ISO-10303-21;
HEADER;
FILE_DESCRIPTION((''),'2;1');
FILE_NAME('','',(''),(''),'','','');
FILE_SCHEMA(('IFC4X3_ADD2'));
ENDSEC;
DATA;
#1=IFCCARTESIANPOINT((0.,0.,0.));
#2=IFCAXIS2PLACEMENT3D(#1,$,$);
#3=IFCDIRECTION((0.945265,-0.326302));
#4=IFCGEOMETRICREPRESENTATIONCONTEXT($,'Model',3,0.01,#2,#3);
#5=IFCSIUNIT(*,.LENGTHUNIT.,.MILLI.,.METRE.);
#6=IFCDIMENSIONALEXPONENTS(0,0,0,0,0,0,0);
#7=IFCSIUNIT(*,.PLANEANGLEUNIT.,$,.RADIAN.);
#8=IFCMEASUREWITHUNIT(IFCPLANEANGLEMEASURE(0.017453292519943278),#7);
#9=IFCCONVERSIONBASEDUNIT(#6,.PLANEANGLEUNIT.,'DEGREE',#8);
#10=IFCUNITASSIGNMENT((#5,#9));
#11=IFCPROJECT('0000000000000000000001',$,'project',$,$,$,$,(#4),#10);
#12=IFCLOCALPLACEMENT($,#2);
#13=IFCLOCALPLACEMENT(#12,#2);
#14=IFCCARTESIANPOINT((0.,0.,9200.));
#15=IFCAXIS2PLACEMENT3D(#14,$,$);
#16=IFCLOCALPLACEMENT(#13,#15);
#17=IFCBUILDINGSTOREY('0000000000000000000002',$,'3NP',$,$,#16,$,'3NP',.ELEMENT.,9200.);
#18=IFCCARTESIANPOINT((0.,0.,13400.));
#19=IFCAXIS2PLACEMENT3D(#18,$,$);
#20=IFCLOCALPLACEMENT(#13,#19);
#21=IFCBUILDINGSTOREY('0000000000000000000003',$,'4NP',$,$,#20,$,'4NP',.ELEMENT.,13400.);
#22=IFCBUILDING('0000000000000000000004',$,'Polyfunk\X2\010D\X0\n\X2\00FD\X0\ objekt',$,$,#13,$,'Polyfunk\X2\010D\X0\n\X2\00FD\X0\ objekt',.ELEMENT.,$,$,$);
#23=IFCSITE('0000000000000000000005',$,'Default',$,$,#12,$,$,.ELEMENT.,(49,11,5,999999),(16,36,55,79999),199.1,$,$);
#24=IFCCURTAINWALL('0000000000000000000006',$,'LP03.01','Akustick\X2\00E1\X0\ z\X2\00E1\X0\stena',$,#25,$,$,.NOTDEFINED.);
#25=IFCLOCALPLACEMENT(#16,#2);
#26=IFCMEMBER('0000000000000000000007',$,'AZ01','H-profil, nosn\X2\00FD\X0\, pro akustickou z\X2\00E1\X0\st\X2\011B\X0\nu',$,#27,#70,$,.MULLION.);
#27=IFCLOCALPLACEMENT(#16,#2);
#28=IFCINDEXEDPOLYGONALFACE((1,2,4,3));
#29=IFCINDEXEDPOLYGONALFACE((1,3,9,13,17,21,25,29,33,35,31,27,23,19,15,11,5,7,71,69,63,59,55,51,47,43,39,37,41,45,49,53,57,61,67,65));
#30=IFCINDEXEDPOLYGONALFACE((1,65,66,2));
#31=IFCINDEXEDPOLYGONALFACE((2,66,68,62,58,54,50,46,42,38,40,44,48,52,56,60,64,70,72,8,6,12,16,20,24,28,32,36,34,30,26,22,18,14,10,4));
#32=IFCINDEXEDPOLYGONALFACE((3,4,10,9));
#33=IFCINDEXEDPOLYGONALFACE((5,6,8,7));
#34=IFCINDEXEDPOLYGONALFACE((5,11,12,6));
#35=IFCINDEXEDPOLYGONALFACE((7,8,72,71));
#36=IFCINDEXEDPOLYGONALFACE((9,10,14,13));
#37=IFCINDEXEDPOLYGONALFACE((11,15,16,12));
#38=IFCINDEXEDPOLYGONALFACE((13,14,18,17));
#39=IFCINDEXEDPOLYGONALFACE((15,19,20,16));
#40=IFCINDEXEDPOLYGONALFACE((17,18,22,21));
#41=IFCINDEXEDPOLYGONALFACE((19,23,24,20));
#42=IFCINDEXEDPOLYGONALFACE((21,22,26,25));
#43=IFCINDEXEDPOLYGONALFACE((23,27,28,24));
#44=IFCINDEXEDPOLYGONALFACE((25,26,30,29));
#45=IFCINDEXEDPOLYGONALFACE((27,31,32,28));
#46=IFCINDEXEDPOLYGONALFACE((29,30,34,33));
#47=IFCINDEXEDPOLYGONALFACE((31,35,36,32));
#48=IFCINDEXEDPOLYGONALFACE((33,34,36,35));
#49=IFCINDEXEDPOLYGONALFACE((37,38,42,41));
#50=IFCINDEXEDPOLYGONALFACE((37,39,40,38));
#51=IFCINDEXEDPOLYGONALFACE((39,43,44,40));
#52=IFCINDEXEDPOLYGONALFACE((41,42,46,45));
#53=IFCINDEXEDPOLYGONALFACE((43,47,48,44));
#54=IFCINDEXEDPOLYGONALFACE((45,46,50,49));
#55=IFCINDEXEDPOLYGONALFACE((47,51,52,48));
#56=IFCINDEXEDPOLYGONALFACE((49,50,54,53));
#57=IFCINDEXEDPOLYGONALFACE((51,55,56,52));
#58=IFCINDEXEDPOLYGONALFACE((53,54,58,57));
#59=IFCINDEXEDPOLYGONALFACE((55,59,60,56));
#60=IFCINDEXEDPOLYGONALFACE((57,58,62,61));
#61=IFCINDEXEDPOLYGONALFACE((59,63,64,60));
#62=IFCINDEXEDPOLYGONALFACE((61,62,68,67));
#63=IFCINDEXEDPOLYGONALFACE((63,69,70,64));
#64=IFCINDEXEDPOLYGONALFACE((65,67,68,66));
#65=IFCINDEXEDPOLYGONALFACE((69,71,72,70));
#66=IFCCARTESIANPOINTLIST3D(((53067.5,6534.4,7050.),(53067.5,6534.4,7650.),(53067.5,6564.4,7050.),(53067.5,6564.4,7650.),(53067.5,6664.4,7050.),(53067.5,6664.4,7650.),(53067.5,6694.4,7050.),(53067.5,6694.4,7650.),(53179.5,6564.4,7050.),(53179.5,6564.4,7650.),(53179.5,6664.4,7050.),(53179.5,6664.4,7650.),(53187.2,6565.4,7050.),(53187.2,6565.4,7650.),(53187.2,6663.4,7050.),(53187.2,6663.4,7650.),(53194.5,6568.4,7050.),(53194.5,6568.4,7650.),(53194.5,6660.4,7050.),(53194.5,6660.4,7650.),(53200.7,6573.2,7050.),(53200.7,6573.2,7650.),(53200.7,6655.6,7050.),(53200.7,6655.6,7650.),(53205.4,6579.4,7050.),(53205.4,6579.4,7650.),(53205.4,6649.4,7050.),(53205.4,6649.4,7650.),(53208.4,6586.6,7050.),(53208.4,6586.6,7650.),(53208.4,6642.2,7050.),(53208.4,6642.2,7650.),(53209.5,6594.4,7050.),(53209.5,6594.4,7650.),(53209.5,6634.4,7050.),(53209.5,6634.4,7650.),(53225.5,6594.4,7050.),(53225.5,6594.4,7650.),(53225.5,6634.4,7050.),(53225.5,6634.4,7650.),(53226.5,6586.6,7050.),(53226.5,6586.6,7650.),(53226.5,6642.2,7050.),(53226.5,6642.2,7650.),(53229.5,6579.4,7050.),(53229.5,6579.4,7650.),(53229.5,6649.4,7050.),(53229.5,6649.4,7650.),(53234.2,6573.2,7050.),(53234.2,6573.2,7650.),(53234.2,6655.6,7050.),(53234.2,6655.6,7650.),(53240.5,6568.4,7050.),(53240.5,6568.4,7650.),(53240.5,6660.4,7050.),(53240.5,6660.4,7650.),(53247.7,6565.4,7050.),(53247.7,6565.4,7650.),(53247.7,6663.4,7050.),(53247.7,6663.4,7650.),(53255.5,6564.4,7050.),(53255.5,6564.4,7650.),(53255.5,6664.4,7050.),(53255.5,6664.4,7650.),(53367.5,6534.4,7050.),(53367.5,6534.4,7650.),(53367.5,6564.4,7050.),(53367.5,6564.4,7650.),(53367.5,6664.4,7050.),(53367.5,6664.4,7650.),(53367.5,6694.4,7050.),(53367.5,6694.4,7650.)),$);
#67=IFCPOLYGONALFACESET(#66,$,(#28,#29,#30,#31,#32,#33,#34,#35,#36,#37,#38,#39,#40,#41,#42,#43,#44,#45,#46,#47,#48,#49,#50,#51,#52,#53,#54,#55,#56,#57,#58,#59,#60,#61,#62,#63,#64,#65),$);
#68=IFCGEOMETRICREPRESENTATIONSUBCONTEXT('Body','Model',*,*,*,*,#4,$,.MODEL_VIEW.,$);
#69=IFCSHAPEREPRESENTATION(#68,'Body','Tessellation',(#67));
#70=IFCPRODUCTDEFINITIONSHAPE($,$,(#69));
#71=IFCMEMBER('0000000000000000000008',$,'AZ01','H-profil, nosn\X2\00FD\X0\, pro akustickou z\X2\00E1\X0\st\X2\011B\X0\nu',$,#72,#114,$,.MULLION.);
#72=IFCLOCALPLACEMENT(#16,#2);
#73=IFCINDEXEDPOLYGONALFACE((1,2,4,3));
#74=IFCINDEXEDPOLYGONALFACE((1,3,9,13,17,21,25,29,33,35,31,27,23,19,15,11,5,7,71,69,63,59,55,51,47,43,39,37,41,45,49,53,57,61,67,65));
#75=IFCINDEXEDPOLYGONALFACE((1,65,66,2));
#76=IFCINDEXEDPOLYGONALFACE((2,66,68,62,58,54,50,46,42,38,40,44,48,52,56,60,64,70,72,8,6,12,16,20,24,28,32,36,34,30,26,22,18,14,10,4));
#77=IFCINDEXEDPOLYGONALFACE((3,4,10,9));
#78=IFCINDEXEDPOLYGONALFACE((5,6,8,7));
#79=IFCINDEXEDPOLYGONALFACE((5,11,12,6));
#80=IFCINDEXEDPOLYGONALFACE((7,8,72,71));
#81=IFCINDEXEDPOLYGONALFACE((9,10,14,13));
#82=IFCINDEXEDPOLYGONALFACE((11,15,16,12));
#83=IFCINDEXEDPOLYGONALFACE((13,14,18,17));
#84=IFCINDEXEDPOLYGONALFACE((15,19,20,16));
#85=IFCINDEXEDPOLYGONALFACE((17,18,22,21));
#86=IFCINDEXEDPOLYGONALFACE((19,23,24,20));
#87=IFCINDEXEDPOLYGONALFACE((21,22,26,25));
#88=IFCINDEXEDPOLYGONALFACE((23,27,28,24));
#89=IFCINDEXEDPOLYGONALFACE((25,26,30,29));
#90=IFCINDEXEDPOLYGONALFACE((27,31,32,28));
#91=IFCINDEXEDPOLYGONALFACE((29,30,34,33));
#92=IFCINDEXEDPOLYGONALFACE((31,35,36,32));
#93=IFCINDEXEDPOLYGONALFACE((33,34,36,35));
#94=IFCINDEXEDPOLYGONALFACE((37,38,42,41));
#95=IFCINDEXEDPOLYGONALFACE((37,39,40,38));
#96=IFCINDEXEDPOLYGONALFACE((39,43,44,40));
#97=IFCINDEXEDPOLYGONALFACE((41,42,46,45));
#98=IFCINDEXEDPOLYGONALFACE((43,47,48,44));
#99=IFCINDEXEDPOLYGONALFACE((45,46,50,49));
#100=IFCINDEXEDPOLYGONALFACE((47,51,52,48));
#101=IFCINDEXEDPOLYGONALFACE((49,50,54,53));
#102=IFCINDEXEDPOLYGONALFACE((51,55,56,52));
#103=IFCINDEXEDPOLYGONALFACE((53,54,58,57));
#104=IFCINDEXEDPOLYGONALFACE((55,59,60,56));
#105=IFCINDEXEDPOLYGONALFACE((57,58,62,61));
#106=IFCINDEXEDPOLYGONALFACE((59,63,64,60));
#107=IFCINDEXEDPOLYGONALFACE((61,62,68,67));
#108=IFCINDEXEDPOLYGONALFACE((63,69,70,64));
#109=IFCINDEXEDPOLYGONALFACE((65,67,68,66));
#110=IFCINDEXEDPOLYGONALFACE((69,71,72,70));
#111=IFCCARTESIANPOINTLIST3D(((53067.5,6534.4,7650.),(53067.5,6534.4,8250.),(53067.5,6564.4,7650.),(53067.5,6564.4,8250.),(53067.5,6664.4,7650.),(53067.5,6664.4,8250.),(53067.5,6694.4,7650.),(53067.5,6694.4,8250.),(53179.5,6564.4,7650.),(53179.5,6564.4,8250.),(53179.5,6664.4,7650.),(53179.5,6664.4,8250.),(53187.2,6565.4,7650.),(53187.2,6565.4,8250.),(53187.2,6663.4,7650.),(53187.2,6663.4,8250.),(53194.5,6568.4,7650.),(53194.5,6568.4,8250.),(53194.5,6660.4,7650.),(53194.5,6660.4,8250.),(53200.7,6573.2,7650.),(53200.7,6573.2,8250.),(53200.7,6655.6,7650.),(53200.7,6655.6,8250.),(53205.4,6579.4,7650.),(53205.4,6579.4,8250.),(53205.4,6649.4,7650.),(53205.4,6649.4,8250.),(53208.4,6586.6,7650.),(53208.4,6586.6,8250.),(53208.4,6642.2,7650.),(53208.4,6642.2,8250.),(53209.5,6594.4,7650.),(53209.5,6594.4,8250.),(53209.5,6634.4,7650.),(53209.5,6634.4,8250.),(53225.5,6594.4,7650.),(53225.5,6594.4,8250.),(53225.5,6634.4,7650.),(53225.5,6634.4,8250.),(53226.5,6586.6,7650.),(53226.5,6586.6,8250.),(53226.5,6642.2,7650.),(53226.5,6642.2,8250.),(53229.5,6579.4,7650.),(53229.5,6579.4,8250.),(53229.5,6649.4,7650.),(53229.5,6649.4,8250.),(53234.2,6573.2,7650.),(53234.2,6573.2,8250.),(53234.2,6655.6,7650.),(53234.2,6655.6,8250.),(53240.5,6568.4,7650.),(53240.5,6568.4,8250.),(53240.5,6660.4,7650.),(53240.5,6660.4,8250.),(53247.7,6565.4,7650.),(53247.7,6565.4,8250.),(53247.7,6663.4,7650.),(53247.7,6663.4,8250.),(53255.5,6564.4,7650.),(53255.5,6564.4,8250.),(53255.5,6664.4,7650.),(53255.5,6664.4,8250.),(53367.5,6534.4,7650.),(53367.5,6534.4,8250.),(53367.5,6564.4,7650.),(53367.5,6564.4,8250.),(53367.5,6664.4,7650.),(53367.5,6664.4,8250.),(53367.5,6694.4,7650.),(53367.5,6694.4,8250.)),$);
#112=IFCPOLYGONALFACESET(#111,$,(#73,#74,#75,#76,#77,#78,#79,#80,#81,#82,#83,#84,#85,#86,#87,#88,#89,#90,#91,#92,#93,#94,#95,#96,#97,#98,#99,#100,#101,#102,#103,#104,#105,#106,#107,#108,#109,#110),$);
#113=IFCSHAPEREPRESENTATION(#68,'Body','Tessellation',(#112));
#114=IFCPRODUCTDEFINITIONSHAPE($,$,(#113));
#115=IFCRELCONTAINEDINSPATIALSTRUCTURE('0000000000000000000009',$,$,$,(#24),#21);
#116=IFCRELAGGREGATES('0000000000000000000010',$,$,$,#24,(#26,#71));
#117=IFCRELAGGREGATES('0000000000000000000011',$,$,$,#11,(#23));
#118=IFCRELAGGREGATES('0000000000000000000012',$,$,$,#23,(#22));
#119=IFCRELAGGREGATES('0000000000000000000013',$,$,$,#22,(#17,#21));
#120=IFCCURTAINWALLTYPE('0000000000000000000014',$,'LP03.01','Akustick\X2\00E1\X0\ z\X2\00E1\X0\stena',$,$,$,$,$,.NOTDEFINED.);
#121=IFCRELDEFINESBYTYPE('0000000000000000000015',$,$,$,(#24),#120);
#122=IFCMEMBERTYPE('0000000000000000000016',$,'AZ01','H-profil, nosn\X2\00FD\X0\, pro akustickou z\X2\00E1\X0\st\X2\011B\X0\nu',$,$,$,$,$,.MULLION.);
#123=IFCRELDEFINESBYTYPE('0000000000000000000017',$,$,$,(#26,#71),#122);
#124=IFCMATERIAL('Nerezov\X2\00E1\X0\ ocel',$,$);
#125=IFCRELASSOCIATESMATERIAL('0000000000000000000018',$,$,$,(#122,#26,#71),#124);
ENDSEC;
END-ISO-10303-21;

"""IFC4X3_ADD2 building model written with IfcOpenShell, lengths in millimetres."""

from ifc_helpers import new_model, entity, si_unit, converted_unit, direction, frame, frame_2d, origin, place, context, subcontext, project, spatial, polyline, circle_curve, parameter, trimmed, segment, composite_curve, outline, extrude, source, transform, mapped, material, material_profile, profile_set, profile_usage, type_object, element, aggregate, save


model = new_model("IFC4X3_ADD2")

# Units and contexts
model_context = context("Model", 3, precision=0.01, world=origin(), true_north=direction((0.945265, -0.326302)))
body_context = subcontext(model_context, "Body", "Model", "MODEL_VIEW")
ifc_project = project(units=[si_unit("LENGTHUNIT", "METRE", prefix="MILLI"), converted_unit("PLANEANGLEUNIT", "DEGREE", entity("IfcPlaneAngleMeasure", 0.017453292519943278), si_unit("PLANEANGLEUNIT", "RADIAN"), dimensions=[0, 0, 0, 0, 0, 0, 0])], contexts=[model_context])

# Site, building, storey
site_placement = place(None, origin())
site = spatial("IfcSite", under=ifc_project, at=site_placement, Name="Default", CompositionType="ELEMENT", RefLatitude=(49, 11, 5, 999999), RefLongitude=(16, 36, 55, 79999), RefElevation=199.1)
building_placement = place(site_placement, origin())
building = spatial("IfcBuilding", under=site, at=building_placement, Name="Polyfunkčný objekt", LongName="Polyfunkčný objekt", CompositionType="ELEMENT")
storey_1_placement = place(building_placement, frame((0.0, 0.0, 9200.0)))
storey_1 = spatial("IfcBuildingStorey", under=building, at=storey_1_placement, Name="3NP", LongName="3NP", CompositionType="ELEMENT", Elevation=9200.0)

# Shared definitions
storey_2_placement = place(building_placement, frame((0.0, 0.0, 13400.0)))
storey_2 = spatial("IfcBuildingStorey", under=building, at=storey_2_placement, Name="4NP", LongName="4NP", CompositionType="ELEMENT", Elevation=13400.0)

# Curtain wall, members
curtain_wall_type_1 = type_object("IfcCurtainWallType", Name="LP03.01", Description="Akustická zástena", PredefinedType="NOTDEFINED")
curtain_wall_1_placement = place(storey_2_placement, frame((0.0, 0.0, -13400.0)))
curtain_wall_1 = element("IfcCurtainWall", 1, at=curtain_wall_1_placement, inside=storey_2, type_object=curtain_wall_type_1, Name="LP03.01", Description="Akustická zástena", PredefinedType="NOTDEFINED")
ifc_material_1 = material(Name="Nerezová ocel")
ifc_material_profile_1 = material_profile(ifc_material_1, outline(composite_curve([segment(polyline([(50.0, -150.0), (80.0, -150.0)]), True, "CONTINUOUS"), segment(polyline([(80.0, -150.0), (80.0, 150.0)]), True, "CONTINUOUS"), segment(polyline([(80.0, 150.0), (50.0, 150.0)]), True, "CONTINUOUS"), segment(polyline([(50.0, 150.0), (50.0, 38.0)]), True, "CONTINUOUS"), segment(trimmed(circle_curve(frame_2d((20.0, 38.0), x_axis=(0.0, 1.0)), 30.0), [parameter(180.0)], [parameter(270.0)], True, "PARAMETER"), False, "CONTINUOUS"), segment(polyline([(20.0, 8.0), (-20.0, 8.0)]), True, "CONTINUOUS"), segment(trimmed(circle_curve(frame_2d((-20.0, 38.0), x_axis=(0.0, 1.0)), 30.0), [parameter(90.0)], [parameter(180.0)], True, "PARAMETER"), False, "CONTINUOUS"), segment(polyline([(-50.0, 38.0), (-50.0, 150.0)]), True, "CONTINUOUS"), segment(polyline([(-50.0, 150.0), (-80.0, 150.0)]), True, "CONTINUOUS"), segment(polyline([(-80.0, 150.0), (-80.0, -150.0)]), True, "CONTINUOUS"), segment(polyline([(-80.0, -150.0), (-50.0, -150.0)]), True, "CONTINUOUS"), segment(polyline([(-50.0, -150.0), (-50.0, -38.0)]), True, "CONTINUOUS"), segment(trimmed(circle_curve(frame_2d((-20.0, -38.0), x_axis=(0.0, 1.0)), 30.0), [parameter(0.0)], [parameter(90.0)], True, "PARAMETER"), False, "CONTINUOUS"), segment(polyline([(-20.0, -8.0), (20.0, -8.0)]), True, "CONTINUOUS"), segment(trimmed(circle_curve(frame_2d((20.0, -38.0), x_axis=(0.0, 1.0)), 30.0), [parameter(270.0)], [parameter(0.0)], True, "PARAMETER"), False, "CONTINUOUS"), segment(polyline([(50.0, -38.0), (50.0, -150.0)]), True, "CONTINUOUS")], self_intersect=False)), Name="Profil zástena")
ifc_profile_set_1 = profile_set([ifc_material_profile_1], Name="Profil zástena")
ifc_profile_usage_1 = profile_usage(ifc_profile_set_1)
member_type_1 = type_object("IfcMemberType", Name="AZ01", Description="H-profil, nosný, pro akustickou zástěnu", PredefinedType="MULLION", material=ifc_profile_set_1)
shared_shape_1 = source(origin(), body_context, "Body", "SweptSolid", [
    extrude(outline(composite_curve([segment(polyline([(50.0, -150.0), (80.0, -150.0)]), True, "CONTINUOUS"), segment(polyline([(80.0, -150.0), (80.0, 150.0)]), True, "CONTINUOUS"), segment(polyline([(80.0, 150.0), (50.0, 150.0)]), True, "CONTINUOUS"), segment(polyline([(50.0, 150.0), (50.0, 38.0)]), True, "CONTINUOUS"), segment(trimmed(circle_curve(frame_2d((20.0, 38.0), x_axis=(0.0, 1.0)), 30.0), [parameter(180.0)], [parameter(270.0)], True, "PARAMETER"), False, "CONTINUOUS"), segment(polyline([(20.0, 8.0), (-20.0, 8.0)]), True, "CONTINUOUS"), segment(trimmed(circle_curve(frame_2d((-20.0, 38.0), x_axis=(0.0, 1.0)), 30.0), [parameter(90.0)], [parameter(180.0)], True, "PARAMETER"), False, "CONTINUOUS"), segment(polyline([(-50.0, 38.0), (-50.0, 150.0)]), True, "CONTINUOUS"), segment(polyline([(-50.0, 150.0), (-80.0, 150.0)]), True, "CONTINUOUS"), segment(polyline([(-80.0, 150.0), (-80.0, -150.0)]), True, "CONTINUOUS"), segment(polyline([(-80.0, -150.0), (-50.0, -150.0)]), True, "CONTINUOUS"), segment(polyline([(-50.0, -150.0), (-50.0, -38.0)]), True, "CONTINUOUS"), segment(trimmed(circle_curve(frame_2d((-20.0, -38.0), x_axis=(0.0, 1.0)), 30.0), [parameter(0.0)], [parameter(90.0)], True, "PARAMETER"), False, "CONTINUOUS"), segment(polyline([(-20.0, -8.0), (20.0, -8.0)]), True, "CONTINUOUS"), segment(trimmed(circle_curve(frame_2d((20.0, -38.0), x_axis=(0.0, 1.0)), 30.0), [parameter(270.0)], [parameter(0.0)], True, "PARAMETER"), False, "CONTINUOUS"), segment(polyline([(50.0, -38.0), (50.0, -150.0)]), True, "CONTINUOUS")], self_intersect=False)), frame((0.0, 0.0, -600.0), z_axis=(0.0, 0.0, 1.0), x_axis=(0.0, -1.0, 0.0)), (0.0, 0.0, 1.0), 600.0),
])
member_1_placement = place(curtain_wall_1_placement, frame((53217.5, 6614.4, 16250.0), z_axis=(0.0, 0.0, -1.0), x_axis=(1.0, 0.0, 0.0)))
member_1 = element("IfcMember", 2, at=member_1_placement, type_object=member_type_1, material=ifc_profile_usage_1, Name="AZ01", Description="H-profil, nosný, pro akustickou zástěnu", PredefinedType="MULLION", context=body_context, shape_type="MappedRepresentation", body=[
    mapped(shared_shape_1, transform((0.0, 0.0, 0.0), scale=1.0)),
])
member_2_placement = place(curtain_wall_1_placement, frame((53217.5, 6614.4, 16850.0), z_axis=(0.0, 0.0, -1.0), x_axis=(1.0, 0.0, 0.0)))
member_2 = element("IfcMember", 3, at=member_2_placement, type_object=member_type_1, material=ifc_profile_usage_1, Name="AZ01", Description="H-profil, nosný, pro akustickou zástěnu", PredefinedType="MULLION", context=body_context, shape_type="MappedRepresentation", body=[
    mapped(shared_shape_1, transform((0.0, 0.0, 0.0), scale=1.0)),
])
aggregate(curtain_wall_1, [member_1, member_2])

save(model, "model.ifc")
